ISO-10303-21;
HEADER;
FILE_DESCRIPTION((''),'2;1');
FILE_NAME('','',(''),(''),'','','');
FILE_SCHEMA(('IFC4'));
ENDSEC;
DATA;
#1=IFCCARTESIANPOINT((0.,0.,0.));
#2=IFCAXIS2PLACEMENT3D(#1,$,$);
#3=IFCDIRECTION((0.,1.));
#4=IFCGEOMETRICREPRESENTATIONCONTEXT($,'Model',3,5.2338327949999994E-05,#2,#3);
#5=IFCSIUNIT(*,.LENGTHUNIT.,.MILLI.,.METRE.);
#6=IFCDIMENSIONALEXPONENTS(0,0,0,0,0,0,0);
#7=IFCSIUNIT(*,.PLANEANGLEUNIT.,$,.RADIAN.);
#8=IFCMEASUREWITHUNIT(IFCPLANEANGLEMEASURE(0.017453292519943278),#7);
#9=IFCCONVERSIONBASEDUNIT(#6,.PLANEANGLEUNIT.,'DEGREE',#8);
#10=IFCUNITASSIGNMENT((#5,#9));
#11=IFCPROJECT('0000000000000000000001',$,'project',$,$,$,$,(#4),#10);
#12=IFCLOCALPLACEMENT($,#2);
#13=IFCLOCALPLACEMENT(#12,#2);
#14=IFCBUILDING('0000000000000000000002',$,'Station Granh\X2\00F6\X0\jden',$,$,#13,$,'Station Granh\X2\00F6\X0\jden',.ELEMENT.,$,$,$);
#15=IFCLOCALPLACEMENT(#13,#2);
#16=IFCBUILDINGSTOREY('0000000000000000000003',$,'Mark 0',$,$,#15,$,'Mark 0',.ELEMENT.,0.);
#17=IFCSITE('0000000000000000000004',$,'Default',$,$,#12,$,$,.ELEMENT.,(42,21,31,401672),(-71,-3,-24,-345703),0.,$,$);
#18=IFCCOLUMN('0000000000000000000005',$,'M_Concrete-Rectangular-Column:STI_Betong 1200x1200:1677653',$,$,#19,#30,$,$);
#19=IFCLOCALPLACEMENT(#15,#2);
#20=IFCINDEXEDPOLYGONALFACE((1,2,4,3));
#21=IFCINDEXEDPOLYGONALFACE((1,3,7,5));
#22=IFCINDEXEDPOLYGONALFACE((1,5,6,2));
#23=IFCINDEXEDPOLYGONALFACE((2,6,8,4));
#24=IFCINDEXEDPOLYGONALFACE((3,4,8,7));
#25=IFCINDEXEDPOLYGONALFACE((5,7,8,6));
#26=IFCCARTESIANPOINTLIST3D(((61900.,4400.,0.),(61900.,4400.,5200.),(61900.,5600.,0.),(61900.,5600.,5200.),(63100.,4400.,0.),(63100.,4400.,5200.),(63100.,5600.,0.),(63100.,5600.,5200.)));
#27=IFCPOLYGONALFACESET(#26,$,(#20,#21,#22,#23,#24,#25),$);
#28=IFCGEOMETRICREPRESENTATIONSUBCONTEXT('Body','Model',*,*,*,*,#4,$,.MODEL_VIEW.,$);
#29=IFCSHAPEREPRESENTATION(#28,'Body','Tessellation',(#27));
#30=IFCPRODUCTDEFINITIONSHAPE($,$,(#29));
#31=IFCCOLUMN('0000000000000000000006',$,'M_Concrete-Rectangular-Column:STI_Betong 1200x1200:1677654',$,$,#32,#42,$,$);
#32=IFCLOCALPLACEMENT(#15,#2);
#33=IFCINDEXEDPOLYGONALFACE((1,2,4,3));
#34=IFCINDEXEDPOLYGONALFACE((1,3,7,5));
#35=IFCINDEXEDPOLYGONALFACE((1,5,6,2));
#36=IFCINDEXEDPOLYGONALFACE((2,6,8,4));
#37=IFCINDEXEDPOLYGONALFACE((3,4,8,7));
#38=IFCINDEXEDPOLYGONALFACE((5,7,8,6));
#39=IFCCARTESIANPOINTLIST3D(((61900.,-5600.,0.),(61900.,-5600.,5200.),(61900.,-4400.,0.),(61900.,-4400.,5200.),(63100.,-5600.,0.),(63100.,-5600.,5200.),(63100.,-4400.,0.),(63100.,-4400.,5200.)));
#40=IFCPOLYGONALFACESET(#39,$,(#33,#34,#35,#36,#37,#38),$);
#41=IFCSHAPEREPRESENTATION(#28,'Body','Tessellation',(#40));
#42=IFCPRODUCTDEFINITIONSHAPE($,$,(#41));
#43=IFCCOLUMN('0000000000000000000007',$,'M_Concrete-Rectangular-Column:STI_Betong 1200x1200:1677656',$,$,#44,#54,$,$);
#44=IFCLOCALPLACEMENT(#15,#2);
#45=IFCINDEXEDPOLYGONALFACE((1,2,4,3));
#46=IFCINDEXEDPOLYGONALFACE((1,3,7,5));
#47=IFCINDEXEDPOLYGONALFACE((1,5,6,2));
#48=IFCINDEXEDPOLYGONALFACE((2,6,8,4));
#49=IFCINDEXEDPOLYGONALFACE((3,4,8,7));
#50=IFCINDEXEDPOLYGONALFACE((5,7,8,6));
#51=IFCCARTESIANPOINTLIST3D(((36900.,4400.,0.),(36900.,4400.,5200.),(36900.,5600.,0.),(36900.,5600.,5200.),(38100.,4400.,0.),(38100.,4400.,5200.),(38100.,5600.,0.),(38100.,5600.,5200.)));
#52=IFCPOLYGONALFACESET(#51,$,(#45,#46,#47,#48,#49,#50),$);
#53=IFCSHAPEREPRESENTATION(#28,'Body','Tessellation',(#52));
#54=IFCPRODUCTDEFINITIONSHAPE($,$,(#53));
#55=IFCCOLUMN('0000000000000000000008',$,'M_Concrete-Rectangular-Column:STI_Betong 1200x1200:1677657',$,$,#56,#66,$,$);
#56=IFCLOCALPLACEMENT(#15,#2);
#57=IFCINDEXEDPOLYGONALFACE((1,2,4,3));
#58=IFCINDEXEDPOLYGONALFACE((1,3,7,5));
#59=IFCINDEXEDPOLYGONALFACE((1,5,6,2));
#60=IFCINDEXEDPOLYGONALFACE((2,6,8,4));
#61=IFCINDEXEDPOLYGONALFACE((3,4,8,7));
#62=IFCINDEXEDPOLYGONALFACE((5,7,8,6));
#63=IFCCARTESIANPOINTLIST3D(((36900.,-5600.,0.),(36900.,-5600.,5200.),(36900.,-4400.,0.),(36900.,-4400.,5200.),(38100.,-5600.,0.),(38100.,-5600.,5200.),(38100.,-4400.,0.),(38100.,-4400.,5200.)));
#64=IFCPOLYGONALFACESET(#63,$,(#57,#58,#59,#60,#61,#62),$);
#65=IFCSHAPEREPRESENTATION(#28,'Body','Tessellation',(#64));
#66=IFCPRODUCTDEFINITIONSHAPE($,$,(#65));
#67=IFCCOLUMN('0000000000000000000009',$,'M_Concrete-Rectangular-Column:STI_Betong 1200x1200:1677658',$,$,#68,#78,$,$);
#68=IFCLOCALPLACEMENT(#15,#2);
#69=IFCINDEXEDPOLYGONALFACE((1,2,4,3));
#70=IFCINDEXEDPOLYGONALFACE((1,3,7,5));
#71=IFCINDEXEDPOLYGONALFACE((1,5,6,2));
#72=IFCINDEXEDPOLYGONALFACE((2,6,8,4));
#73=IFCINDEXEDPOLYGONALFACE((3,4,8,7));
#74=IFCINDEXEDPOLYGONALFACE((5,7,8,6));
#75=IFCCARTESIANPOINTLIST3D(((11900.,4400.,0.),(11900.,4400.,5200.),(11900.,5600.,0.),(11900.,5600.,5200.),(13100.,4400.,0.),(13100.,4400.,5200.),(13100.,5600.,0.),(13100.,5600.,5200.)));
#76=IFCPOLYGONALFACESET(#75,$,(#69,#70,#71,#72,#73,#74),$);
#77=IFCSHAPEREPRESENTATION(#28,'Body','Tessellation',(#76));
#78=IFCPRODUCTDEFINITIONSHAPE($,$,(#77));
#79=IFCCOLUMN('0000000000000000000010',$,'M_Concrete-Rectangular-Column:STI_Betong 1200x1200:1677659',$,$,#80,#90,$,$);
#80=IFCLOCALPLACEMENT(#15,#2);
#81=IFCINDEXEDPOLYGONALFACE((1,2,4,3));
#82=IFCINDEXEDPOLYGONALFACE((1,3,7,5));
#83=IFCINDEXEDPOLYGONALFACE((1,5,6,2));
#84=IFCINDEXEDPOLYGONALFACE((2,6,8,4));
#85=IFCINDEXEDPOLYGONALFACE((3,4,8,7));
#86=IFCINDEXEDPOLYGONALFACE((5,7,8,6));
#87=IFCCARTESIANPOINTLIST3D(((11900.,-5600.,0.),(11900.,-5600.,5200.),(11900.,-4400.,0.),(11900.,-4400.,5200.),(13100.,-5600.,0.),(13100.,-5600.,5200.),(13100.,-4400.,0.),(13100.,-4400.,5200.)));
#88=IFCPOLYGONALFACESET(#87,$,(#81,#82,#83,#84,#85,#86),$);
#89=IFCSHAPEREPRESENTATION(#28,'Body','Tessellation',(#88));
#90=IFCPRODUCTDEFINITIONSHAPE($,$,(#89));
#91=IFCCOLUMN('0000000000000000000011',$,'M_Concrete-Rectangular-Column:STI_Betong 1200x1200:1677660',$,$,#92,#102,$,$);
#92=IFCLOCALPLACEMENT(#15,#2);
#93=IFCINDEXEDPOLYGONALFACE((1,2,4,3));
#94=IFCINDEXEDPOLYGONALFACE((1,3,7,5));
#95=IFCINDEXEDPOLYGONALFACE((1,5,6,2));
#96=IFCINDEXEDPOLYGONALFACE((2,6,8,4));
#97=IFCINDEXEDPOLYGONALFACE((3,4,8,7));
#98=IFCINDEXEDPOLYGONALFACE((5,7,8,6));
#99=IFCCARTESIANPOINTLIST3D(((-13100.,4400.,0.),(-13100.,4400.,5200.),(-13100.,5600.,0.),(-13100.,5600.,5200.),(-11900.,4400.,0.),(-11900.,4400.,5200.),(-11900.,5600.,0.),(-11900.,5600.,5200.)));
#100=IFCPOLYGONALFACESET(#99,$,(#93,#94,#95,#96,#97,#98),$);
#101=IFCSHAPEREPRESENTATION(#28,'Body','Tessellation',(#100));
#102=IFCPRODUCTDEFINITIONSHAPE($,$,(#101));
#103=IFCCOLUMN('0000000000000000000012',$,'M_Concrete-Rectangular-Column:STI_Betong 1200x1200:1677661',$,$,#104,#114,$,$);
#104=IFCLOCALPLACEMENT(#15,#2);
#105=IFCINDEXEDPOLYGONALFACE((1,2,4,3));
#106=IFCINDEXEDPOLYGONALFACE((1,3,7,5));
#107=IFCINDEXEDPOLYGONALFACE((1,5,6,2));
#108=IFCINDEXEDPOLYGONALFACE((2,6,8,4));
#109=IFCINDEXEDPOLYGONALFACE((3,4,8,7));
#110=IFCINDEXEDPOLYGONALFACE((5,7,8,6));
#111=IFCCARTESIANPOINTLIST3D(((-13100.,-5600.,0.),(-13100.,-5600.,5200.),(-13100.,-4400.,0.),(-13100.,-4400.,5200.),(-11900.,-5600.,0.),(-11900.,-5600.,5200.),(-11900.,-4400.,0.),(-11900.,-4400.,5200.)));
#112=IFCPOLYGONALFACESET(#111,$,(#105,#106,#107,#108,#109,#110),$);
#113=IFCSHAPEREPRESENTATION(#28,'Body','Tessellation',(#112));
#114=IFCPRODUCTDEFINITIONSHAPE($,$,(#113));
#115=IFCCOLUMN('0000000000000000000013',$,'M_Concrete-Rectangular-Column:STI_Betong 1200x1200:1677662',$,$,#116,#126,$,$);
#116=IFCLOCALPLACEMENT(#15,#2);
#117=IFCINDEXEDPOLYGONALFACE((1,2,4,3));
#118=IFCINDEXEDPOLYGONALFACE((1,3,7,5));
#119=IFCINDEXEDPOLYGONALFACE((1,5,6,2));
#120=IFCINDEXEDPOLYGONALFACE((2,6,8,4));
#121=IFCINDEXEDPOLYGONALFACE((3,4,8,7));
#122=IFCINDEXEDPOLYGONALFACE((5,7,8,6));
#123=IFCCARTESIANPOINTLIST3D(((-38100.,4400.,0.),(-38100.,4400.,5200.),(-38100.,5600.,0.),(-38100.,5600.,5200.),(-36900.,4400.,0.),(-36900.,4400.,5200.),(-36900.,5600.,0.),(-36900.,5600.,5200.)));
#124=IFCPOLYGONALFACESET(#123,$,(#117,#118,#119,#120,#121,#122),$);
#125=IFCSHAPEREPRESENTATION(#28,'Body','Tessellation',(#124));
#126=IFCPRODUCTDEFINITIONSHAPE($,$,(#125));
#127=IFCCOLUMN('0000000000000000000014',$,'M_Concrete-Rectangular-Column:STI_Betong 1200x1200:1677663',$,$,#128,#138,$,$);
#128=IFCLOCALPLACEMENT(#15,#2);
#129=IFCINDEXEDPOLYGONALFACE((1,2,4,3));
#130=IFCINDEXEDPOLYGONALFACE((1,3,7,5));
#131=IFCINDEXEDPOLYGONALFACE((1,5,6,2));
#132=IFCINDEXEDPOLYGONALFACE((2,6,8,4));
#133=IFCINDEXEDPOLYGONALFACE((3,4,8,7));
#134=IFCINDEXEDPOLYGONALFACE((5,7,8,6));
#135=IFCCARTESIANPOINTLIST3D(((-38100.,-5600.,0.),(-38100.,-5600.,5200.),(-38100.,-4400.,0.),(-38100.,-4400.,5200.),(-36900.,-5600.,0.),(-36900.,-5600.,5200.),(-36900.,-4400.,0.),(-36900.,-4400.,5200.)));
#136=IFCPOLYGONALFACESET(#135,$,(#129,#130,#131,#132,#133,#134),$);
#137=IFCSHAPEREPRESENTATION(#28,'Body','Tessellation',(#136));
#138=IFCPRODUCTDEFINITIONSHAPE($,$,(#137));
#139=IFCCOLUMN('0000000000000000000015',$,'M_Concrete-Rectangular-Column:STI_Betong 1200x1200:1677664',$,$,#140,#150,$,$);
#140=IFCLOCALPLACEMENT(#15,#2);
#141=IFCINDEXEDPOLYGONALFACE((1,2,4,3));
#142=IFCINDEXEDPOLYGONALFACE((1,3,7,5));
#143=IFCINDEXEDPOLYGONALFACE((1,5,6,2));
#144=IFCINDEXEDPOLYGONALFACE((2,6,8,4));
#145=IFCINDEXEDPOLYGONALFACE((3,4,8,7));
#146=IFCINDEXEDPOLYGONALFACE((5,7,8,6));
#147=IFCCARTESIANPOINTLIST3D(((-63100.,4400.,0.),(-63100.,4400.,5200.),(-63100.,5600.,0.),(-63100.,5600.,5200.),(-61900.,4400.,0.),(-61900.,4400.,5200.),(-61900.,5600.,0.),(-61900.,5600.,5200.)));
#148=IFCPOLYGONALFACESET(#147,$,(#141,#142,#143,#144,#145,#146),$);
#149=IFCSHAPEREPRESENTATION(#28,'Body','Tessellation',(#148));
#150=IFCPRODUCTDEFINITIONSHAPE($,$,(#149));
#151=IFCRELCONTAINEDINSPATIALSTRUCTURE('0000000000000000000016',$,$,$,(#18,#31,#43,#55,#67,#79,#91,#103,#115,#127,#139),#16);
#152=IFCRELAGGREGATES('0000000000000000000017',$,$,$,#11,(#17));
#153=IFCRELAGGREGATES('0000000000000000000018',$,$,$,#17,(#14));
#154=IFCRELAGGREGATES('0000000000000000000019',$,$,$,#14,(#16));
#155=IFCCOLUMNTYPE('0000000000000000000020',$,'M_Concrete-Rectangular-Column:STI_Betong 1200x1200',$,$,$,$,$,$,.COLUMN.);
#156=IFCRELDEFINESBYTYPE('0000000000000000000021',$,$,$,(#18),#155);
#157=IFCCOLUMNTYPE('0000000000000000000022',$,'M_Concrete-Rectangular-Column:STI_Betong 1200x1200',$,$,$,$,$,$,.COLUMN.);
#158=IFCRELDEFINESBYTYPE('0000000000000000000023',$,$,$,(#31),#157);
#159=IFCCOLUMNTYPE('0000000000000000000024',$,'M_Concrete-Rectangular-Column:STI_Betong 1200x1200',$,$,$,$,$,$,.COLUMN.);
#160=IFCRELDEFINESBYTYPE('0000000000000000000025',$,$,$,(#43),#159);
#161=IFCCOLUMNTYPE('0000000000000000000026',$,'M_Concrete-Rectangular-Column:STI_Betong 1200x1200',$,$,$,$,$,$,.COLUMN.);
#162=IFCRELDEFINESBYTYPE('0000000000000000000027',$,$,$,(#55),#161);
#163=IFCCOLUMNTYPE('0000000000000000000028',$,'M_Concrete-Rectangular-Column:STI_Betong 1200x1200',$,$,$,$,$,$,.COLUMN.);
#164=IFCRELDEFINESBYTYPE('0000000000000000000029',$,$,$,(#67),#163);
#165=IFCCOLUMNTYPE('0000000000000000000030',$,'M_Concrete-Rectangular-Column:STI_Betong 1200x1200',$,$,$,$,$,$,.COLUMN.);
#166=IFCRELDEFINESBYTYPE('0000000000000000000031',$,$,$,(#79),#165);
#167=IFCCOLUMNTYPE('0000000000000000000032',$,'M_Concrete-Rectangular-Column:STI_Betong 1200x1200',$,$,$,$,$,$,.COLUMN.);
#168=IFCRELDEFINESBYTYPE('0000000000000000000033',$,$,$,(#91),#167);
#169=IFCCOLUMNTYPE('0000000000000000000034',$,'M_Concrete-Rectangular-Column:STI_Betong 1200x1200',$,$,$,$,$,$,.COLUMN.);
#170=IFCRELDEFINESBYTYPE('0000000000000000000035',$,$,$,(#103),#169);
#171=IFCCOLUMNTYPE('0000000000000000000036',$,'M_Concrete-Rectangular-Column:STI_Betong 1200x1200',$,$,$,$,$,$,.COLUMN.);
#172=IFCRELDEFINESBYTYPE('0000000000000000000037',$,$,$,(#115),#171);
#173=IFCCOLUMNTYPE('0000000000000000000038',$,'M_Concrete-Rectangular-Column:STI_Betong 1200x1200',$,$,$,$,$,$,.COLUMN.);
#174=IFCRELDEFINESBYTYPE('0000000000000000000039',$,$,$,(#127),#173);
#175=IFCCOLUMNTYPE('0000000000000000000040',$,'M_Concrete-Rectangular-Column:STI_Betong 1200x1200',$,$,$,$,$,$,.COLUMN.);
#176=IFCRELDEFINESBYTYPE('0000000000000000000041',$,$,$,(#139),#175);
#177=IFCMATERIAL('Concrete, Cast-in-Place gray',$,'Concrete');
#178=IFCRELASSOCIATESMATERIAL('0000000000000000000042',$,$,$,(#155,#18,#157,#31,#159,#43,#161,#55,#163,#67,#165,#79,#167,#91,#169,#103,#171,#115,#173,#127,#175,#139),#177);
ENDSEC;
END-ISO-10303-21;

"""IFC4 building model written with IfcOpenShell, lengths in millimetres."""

from ifc_helpers import new_model, entity, si_unit, converted_unit, direction, frame, origin, place, context, subcontext, project, spatial, indexed_curve, outline, extrude, source, transform, mapped, material, type_object, type_shapes, element, save


model = new_model("IFC4")

# Units and contexts
model_context = context("Model", 3, precision=5.2338327949999994e-05, world=origin(), true_north=direction((0.0, 1.0)))
body_context = subcontext(model_context, "Body", "Model", "MODEL_VIEW")
ifc_project = project(units=[si_unit("LENGTHUNIT", "METRE", prefix="MILLI"), converted_unit("PLANEANGLEUNIT", "DEGREE", entity("IfcPlaneAngleMeasure", 0.017453292519943278), si_unit("PLANEANGLEUNIT", "RADIAN"), dimensions=[0, 0, 0, 0, 0, 0, 0])], contexts=[model_context])

# Site, building, storey
site_placement = place(None, origin())
site = spatial("IfcSite", under=ifc_project, at=site_placement, Name="Default", CompositionType="ELEMENT", RefLatitude=(42, 21, 31, 401672), RefLongitude=(-71, -3, -24, -345703), RefElevation=0.0)
building_placement = place(site_placement, origin())
building = spatial("IfcBuilding", under=site, at=building_placement, Name="Station Granhöjden", LongName="Station Granhöjden", CompositionType="ELEMENT")
storey_placement = place(building_placement, origin())
storey = spatial("IfcBuildingStorey", under=building, at=storey_placement, Name="Mark 0", LongName="Mark 0", CompositionType="ELEMENT", Elevation=0.0)

# Columns
ifc_material = material(Name="Concrete, Cast-in-Place gray", Category="Concrete")
column_type_1 = type_object("IfcColumnType", Name="M_Concrete-Rectangular-Column:STI_Betong 1200x1200", PredefinedType="COLUMN", material=ifc_material)
shared_shape_1 = source(origin(), body_context, "Body", "SweptSolid", [
    extrude(outline(indexed_curve([(-600.0, -600.0), (600.0, -600.0), (600.0, 600.0), (-600.0, 600.0), (-600.0, -600.0)], self_intersect=False)), frame((62500.0, 5000.0, 0.0), z_axis=(0.0, 0.0, 1.0), x_axis=(-1.0, 0.0, 0.0)), (0.0, 0.0, 1.0), 5200.0),
])
type_shapes(column_type_1, [shared_shape_1])
column_1_placement = place(storey_placement, origin())
element("IfcColumn", 1, at=column_1_placement, inside=storey, type_object=column_type_1, material=ifc_material, Name="M_Concrete-Rectangular-Column:STI_Betong 1200x1200:1677653", context=body_context, shape_type="MappedRepresentation", body=[
    mapped(shared_shape_1, transform((0.0, 0.0, 0.0), scale=1.0)),
])
column_type_2 = type_object("IfcColumnType", Name="M_Concrete-Rectangular-Column:STI_Betong 1200x1200", PredefinedType="COLUMN", material=ifc_material)
shared_shape_2 = source(origin(), body_context, "Body", "SweptSolid", [
    extrude(outline(indexed_curve([(-600.0, -600.0), (600.0, -600.0), (600.0, 600.0), (-600.0, 600.0), (-600.0, -600.0)], self_intersect=False)), frame((62500.0, -5000.0, 0.0), z_axis=(0.0, 0.0, 1.0), x_axis=(-1.0, 0.0, 0.0)), (0.0, 0.0, 1.0), 5200.0),
])
type_shapes(column_type_2, [shared_shape_2])
column_2_placement = place(storey_placement, origin())
element("IfcColumn", 2, at=column_2_placement, inside=storey, type_object=column_type_2, material=ifc_material, Name="M_Concrete-Rectangular-Column:STI_Betong 1200x1200:1677654", context=body_context, shape_type="MappedRepresentation", body=[
    mapped(shared_shape_2, transform((0.0, 0.0, 0.0), scale=1.0)),
])
column_type_3 = type_object("IfcColumnType", Name="M_Concrete-Rectangular-Column:STI_Betong 1200x1200", PredefinedType="COLUMN", material=ifc_material)
shared_shape_3 = source(origin(), body_context, "Body", "SweptSolid", [
    extrude(outline(indexed_curve([(-600.0, -600.0), (600.0, -600.0), (600.0, 600.0), (-600.0, 600.0), (-600.0, -600.0)], self_intersect=False)), frame((37500.0, 5000.0, 0.0), z_axis=(0.0, 0.0, 1.0), x_axis=(-1.0, 0.0, 0.0)), (0.0, 0.0, 1.0), 5200.0),
])
type_shapes(column_type_3, [shared_shape_3])
column_3_placement = place(storey_placement, origin())
element("IfcColumn", 3, at=column_3_placement, inside=storey, type_object=column_type_3, material=ifc_material, Name="M_Concrete-Rectangular-Column:STI_Betong 1200x1200:1677656", context=body_context, shape_type="MappedRepresentation", body=[
    mapped(shared_shape_3, transform((0.0, 0.0, 0.0), scale=1.0)),
])
column_type_4 = type_object("IfcColumnType", Name="M_Concrete-Rectangular-Column:STI_Betong 1200x1200", PredefinedType="COLUMN", material=ifc_material)
shared_shape_4 = source(origin(), body_context, "Body", "SweptSolid", [
    extrude(outline(indexed_curve([(-600.0, -600.0), (600.0, -600.0), (600.0, 600.0), (-600.0, 600.0), (-600.0, -600.0)], self_intersect=False)), frame((37500.0, -5000.0, 0.0), z_axis=(0.0, 0.0, 1.0), x_axis=(-1.0, 0.0, 0.0)), (0.0, 0.0, 1.0), 5200.0),
])
type_shapes(column_type_4, [shared_shape_4])
column_4_placement = place(storey_placement, origin())
element("IfcColumn", 4, at=column_4_placement, inside=storey, type_object=column_type_4, material=ifc_material, Name="M_Concrete-Rectangular-Column:STI_Betong 1200x1200:1677657", context=body_context, shape_type="MappedRepresentation", body=[
    mapped(shared_shape_4, transform((0.0, 0.0, 0.0), scale=1.0)),
])
column_type_5 = type_object("IfcColumnType", Name="M_Concrete-Rectangular-Column:STI_Betong 1200x1200", PredefinedType="COLUMN", material=ifc_material)
shared_shape_5 = source(origin(), body_context, "Body", "SweptSolid", [
    extrude(outline(indexed_curve([(-600.0, -600.0), (600.0, -600.0), (600.0, 600.0), (-600.0, 600.0), (-600.0, -600.0)], self_intersect=False)), frame((12500.0, 5000.0, 0.0), z_axis=(0.0, 0.0, 1.0), x_axis=(-1.0, 0.0, 0.0)), (0.0, 0.0, 1.0), 5200.0),
])
type_shapes(column_type_5, [shared_shape_5])
column_5_placement = place(storey_placement, origin())
element("IfcColumn", 5, at=column_5_placement, inside=storey, type_object=column_type_5, material=ifc_material, Name="M_Concrete-Rectangular-Column:STI_Betong 1200x1200:1677658", context=body_context, shape_type="MappedRepresentation", body=[
    mapped(shared_shape_5, transform((0.0, 0.0, 0.0), scale=1.0)),
])
column_type_6 = type_object("IfcColumnType", Name="M_Concrete-Rectangular-Column:STI_Betong 1200x1200", PredefinedType="COLUMN", material=ifc_material)
shared_shape_6 = source(origin(), body_context, "Body", "SweptSolid", [
    extrude(outline(indexed_curve([(-600.0, -600.0), (600.0, -600.0), (600.0, 600.0), (-600.0, 600.0), (-600.0, -600.0)], self_intersect=False)), frame((12500.0, -5000.0, 0.0), z_axis=(0.0, 0.0, 1.0), x_axis=(-1.0, 0.0, 0.0)), (0.0, 0.0, 1.0), 5200.0),
])
type_shapes(column_type_6, [shared_shape_6])
column_6_placement = place(storey_placement, origin())
element("IfcColumn", 6, at=column_6_placement, inside=storey, type_object=column_type_6, material=ifc_material, Name="M_Concrete-Rectangular-Column:STI_Betong 1200x1200:1677659", context=body_context, shape_type="MappedRepresentation", body=[
    mapped(shared_shape_6, transform((0.0, 0.0, 0.0), scale=1.0)),
])
column_type_7 = type_object("IfcColumnType", Name="M_Concrete-Rectangular-Column:STI_Betong 1200x1200", PredefinedType="COLUMN", material=ifc_material)
shared_shape_7 = source(origin(), body_context, "Body", "SweptSolid", [
    extrude(outline(indexed_curve([(-600.0, -600.0), (600.0, -600.0), (600.0, 600.0), (-600.0, 600.0), (-600.0, -600.0)], self_intersect=False)), frame((-12500.0, 5000.0, 0.0), z_axis=(0.0, 0.0, 1.0), x_axis=(-1.0, 0.0, 0.0)), (0.0, 0.0, 1.0), 5200.0),
])
type_shapes(column_type_7, [shared_shape_7])
column_7_placement = place(storey_placement, origin())
element("IfcColumn", 7, at=column_7_placement, inside=storey, type_object=column_type_7, material=ifc_material, Name="M_Concrete-Rectangular-Column:STI_Betong 1200x1200:1677660", context=body_context, shape_type="MappedRepresentation", body=[
    mapped(shared_shape_7, transform((0.0, 0.0, 0.0), scale=1.0)),
])
column_type_8 = type_object("IfcColumnType", Name="M_Concrete-Rectangular-Column:STI_Betong 1200x1200", PredefinedType="COLUMN", material=ifc_material)
shared_shape_8 = source(origin(), body_context, "Body", "SweptSolid", [
    extrude(outline(indexed_curve([(-600.0, -600.0), (600.0, -600.0), (600.0, 600.0), (-600.0, 600.0), (-600.0, -600.0)], self_intersect=False)), frame((-12500.0, -5000.0, 0.0), z_axis=(0.0, 0.0, 1.0), x_axis=(-1.0, 0.0, 0.0)), (0.0, 0.0, 1.0), 5200.0),
])
type_shapes(column_type_8, [shared_shape_8])
column_8_placement = place(storey_placement, origin())
element("IfcColumn", 8, at=column_8_placement, inside=storey, type_object=column_type_8, material=ifc_material, Name="M_Concrete-Rectangular-Column:STI_Betong 1200x1200:1677661", context=body_context, shape_type="MappedRepresentation", body=[
    mapped(shared_shape_8, transform((0.0, 0.0, 0.0), scale=1.0)),
])
column_type_9 = type_object("IfcColumnType", Name="M_Concrete-Rectangular-Column:STI_Betong 1200x1200", PredefinedType="COLUMN", material=ifc_material)
shared_shape_9 = source(origin(), body_context, "Body", "SweptSolid", [
    extrude(outline(indexed_curve([(-600.0, -600.0), (600.0, -600.0), (600.0, 600.0), (-600.0, 600.0), (-600.0, -600.0)], self_intersect=False)), frame((-37500.0, 5000.0, 0.0), z_axis=(0.0, 0.0, 1.0), x_axis=(-1.0, 0.0, 0.0)), (0.0, 0.0, 1.0), 5200.0),
])
type_shapes(column_type_9, [shared_shape_9])
column_9_placement = place(storey_placement, origin())
element("IfcColumn", 9, at=column_9_placement, inside=storey, type_object=column_type_9, material=ifc_material, Name="M_Concrete-Rectangular-Column:STI_Betong 1200x1200:1677662", context=body_context, shape_type="MappedRepresentation", body=[
    mapped(shared_shape_9, transform((0.0, 0.0, 0.0), scale=1.0)),
])
column_type_10 = type_object("IfcColumnType", Name="M_Concrete-Rectangular-Column:STI_Betong 1200x1200", PredefinedType="COLUMN", material=ifc_material)
shared_shape_10 = source(origin(), body_context, "Body", "SweptSolid", [
    extrude(outline(indexed_curve([(-600.0, -600.0), (600.0, -600.0), (600.0, 600.0), (-600.0, 600.0), (-600.0, -600.0)], self_intersect=False)), frame((-37500.0, -5000.0, 0.0), z_axis=(0.0, 0.0, 1.0), x_axis=(-1.0, 0.0, 0.0)), (0.0, 0.0, 1.0), 5200.0),
])
type_shapes(column_type_10, [shared_shape_10])
column_10_placement = place(storey_placement, origin())
element("IfcColumn", 10, at=column_10_placement, inside=storey, type_object=column_type_10, material=ifc_material, Name="M_Concrete-Rectangular-Column:STI_Betong 1200x1200:1677663", context=body_context, shape_type="MappedRepresentation", body=[
    mapped(shared_shape_10, transform((0.0, 0.0, 0.0), scale=1.0)),
])
column_type_11 = type_object("IfcColumnType", Name="M_Concrete-Rectangular-Column:STI_Betong 1200x1200", PredefinedType="COLUMN", material=ifc_material)
shared_shape_11 = source(origin(), body_context, "Body", "SweptSolid", [
    extrude(outline(indexed_curve([(-600.0, -600.0), (600.0, -600.0), (600.0, 600.0), (-600.0, 600.0), (-600.0, -600.0)], self_intersect=False)), frame((-62500.0, 5000.0, 0.0), z_axis=(0.0, 0.0, 1.0), x_axis=(-1.0, 0.0, 0.0)), (0.0, 0.0, 1.0), 5200.0),
])
type_shapes(column_type_11, [shared_shape_11])
column_11_placement = place(storey_placement, origin())
element("IfcColumn", 11, at=column_11_placement, inside=storey, type_object=column_type_11, material=ifc_material, Name="M_Concrete-Rectangular-Column:STI_Betong 1200x1200:1677664", context=body_context, shape_type="MappedRepresentation", body=[
    mapped(shared_shape_11, transform((0.0, 0.0, 0.0), scale=1.0)),
])

save(model, "model.ifc")
